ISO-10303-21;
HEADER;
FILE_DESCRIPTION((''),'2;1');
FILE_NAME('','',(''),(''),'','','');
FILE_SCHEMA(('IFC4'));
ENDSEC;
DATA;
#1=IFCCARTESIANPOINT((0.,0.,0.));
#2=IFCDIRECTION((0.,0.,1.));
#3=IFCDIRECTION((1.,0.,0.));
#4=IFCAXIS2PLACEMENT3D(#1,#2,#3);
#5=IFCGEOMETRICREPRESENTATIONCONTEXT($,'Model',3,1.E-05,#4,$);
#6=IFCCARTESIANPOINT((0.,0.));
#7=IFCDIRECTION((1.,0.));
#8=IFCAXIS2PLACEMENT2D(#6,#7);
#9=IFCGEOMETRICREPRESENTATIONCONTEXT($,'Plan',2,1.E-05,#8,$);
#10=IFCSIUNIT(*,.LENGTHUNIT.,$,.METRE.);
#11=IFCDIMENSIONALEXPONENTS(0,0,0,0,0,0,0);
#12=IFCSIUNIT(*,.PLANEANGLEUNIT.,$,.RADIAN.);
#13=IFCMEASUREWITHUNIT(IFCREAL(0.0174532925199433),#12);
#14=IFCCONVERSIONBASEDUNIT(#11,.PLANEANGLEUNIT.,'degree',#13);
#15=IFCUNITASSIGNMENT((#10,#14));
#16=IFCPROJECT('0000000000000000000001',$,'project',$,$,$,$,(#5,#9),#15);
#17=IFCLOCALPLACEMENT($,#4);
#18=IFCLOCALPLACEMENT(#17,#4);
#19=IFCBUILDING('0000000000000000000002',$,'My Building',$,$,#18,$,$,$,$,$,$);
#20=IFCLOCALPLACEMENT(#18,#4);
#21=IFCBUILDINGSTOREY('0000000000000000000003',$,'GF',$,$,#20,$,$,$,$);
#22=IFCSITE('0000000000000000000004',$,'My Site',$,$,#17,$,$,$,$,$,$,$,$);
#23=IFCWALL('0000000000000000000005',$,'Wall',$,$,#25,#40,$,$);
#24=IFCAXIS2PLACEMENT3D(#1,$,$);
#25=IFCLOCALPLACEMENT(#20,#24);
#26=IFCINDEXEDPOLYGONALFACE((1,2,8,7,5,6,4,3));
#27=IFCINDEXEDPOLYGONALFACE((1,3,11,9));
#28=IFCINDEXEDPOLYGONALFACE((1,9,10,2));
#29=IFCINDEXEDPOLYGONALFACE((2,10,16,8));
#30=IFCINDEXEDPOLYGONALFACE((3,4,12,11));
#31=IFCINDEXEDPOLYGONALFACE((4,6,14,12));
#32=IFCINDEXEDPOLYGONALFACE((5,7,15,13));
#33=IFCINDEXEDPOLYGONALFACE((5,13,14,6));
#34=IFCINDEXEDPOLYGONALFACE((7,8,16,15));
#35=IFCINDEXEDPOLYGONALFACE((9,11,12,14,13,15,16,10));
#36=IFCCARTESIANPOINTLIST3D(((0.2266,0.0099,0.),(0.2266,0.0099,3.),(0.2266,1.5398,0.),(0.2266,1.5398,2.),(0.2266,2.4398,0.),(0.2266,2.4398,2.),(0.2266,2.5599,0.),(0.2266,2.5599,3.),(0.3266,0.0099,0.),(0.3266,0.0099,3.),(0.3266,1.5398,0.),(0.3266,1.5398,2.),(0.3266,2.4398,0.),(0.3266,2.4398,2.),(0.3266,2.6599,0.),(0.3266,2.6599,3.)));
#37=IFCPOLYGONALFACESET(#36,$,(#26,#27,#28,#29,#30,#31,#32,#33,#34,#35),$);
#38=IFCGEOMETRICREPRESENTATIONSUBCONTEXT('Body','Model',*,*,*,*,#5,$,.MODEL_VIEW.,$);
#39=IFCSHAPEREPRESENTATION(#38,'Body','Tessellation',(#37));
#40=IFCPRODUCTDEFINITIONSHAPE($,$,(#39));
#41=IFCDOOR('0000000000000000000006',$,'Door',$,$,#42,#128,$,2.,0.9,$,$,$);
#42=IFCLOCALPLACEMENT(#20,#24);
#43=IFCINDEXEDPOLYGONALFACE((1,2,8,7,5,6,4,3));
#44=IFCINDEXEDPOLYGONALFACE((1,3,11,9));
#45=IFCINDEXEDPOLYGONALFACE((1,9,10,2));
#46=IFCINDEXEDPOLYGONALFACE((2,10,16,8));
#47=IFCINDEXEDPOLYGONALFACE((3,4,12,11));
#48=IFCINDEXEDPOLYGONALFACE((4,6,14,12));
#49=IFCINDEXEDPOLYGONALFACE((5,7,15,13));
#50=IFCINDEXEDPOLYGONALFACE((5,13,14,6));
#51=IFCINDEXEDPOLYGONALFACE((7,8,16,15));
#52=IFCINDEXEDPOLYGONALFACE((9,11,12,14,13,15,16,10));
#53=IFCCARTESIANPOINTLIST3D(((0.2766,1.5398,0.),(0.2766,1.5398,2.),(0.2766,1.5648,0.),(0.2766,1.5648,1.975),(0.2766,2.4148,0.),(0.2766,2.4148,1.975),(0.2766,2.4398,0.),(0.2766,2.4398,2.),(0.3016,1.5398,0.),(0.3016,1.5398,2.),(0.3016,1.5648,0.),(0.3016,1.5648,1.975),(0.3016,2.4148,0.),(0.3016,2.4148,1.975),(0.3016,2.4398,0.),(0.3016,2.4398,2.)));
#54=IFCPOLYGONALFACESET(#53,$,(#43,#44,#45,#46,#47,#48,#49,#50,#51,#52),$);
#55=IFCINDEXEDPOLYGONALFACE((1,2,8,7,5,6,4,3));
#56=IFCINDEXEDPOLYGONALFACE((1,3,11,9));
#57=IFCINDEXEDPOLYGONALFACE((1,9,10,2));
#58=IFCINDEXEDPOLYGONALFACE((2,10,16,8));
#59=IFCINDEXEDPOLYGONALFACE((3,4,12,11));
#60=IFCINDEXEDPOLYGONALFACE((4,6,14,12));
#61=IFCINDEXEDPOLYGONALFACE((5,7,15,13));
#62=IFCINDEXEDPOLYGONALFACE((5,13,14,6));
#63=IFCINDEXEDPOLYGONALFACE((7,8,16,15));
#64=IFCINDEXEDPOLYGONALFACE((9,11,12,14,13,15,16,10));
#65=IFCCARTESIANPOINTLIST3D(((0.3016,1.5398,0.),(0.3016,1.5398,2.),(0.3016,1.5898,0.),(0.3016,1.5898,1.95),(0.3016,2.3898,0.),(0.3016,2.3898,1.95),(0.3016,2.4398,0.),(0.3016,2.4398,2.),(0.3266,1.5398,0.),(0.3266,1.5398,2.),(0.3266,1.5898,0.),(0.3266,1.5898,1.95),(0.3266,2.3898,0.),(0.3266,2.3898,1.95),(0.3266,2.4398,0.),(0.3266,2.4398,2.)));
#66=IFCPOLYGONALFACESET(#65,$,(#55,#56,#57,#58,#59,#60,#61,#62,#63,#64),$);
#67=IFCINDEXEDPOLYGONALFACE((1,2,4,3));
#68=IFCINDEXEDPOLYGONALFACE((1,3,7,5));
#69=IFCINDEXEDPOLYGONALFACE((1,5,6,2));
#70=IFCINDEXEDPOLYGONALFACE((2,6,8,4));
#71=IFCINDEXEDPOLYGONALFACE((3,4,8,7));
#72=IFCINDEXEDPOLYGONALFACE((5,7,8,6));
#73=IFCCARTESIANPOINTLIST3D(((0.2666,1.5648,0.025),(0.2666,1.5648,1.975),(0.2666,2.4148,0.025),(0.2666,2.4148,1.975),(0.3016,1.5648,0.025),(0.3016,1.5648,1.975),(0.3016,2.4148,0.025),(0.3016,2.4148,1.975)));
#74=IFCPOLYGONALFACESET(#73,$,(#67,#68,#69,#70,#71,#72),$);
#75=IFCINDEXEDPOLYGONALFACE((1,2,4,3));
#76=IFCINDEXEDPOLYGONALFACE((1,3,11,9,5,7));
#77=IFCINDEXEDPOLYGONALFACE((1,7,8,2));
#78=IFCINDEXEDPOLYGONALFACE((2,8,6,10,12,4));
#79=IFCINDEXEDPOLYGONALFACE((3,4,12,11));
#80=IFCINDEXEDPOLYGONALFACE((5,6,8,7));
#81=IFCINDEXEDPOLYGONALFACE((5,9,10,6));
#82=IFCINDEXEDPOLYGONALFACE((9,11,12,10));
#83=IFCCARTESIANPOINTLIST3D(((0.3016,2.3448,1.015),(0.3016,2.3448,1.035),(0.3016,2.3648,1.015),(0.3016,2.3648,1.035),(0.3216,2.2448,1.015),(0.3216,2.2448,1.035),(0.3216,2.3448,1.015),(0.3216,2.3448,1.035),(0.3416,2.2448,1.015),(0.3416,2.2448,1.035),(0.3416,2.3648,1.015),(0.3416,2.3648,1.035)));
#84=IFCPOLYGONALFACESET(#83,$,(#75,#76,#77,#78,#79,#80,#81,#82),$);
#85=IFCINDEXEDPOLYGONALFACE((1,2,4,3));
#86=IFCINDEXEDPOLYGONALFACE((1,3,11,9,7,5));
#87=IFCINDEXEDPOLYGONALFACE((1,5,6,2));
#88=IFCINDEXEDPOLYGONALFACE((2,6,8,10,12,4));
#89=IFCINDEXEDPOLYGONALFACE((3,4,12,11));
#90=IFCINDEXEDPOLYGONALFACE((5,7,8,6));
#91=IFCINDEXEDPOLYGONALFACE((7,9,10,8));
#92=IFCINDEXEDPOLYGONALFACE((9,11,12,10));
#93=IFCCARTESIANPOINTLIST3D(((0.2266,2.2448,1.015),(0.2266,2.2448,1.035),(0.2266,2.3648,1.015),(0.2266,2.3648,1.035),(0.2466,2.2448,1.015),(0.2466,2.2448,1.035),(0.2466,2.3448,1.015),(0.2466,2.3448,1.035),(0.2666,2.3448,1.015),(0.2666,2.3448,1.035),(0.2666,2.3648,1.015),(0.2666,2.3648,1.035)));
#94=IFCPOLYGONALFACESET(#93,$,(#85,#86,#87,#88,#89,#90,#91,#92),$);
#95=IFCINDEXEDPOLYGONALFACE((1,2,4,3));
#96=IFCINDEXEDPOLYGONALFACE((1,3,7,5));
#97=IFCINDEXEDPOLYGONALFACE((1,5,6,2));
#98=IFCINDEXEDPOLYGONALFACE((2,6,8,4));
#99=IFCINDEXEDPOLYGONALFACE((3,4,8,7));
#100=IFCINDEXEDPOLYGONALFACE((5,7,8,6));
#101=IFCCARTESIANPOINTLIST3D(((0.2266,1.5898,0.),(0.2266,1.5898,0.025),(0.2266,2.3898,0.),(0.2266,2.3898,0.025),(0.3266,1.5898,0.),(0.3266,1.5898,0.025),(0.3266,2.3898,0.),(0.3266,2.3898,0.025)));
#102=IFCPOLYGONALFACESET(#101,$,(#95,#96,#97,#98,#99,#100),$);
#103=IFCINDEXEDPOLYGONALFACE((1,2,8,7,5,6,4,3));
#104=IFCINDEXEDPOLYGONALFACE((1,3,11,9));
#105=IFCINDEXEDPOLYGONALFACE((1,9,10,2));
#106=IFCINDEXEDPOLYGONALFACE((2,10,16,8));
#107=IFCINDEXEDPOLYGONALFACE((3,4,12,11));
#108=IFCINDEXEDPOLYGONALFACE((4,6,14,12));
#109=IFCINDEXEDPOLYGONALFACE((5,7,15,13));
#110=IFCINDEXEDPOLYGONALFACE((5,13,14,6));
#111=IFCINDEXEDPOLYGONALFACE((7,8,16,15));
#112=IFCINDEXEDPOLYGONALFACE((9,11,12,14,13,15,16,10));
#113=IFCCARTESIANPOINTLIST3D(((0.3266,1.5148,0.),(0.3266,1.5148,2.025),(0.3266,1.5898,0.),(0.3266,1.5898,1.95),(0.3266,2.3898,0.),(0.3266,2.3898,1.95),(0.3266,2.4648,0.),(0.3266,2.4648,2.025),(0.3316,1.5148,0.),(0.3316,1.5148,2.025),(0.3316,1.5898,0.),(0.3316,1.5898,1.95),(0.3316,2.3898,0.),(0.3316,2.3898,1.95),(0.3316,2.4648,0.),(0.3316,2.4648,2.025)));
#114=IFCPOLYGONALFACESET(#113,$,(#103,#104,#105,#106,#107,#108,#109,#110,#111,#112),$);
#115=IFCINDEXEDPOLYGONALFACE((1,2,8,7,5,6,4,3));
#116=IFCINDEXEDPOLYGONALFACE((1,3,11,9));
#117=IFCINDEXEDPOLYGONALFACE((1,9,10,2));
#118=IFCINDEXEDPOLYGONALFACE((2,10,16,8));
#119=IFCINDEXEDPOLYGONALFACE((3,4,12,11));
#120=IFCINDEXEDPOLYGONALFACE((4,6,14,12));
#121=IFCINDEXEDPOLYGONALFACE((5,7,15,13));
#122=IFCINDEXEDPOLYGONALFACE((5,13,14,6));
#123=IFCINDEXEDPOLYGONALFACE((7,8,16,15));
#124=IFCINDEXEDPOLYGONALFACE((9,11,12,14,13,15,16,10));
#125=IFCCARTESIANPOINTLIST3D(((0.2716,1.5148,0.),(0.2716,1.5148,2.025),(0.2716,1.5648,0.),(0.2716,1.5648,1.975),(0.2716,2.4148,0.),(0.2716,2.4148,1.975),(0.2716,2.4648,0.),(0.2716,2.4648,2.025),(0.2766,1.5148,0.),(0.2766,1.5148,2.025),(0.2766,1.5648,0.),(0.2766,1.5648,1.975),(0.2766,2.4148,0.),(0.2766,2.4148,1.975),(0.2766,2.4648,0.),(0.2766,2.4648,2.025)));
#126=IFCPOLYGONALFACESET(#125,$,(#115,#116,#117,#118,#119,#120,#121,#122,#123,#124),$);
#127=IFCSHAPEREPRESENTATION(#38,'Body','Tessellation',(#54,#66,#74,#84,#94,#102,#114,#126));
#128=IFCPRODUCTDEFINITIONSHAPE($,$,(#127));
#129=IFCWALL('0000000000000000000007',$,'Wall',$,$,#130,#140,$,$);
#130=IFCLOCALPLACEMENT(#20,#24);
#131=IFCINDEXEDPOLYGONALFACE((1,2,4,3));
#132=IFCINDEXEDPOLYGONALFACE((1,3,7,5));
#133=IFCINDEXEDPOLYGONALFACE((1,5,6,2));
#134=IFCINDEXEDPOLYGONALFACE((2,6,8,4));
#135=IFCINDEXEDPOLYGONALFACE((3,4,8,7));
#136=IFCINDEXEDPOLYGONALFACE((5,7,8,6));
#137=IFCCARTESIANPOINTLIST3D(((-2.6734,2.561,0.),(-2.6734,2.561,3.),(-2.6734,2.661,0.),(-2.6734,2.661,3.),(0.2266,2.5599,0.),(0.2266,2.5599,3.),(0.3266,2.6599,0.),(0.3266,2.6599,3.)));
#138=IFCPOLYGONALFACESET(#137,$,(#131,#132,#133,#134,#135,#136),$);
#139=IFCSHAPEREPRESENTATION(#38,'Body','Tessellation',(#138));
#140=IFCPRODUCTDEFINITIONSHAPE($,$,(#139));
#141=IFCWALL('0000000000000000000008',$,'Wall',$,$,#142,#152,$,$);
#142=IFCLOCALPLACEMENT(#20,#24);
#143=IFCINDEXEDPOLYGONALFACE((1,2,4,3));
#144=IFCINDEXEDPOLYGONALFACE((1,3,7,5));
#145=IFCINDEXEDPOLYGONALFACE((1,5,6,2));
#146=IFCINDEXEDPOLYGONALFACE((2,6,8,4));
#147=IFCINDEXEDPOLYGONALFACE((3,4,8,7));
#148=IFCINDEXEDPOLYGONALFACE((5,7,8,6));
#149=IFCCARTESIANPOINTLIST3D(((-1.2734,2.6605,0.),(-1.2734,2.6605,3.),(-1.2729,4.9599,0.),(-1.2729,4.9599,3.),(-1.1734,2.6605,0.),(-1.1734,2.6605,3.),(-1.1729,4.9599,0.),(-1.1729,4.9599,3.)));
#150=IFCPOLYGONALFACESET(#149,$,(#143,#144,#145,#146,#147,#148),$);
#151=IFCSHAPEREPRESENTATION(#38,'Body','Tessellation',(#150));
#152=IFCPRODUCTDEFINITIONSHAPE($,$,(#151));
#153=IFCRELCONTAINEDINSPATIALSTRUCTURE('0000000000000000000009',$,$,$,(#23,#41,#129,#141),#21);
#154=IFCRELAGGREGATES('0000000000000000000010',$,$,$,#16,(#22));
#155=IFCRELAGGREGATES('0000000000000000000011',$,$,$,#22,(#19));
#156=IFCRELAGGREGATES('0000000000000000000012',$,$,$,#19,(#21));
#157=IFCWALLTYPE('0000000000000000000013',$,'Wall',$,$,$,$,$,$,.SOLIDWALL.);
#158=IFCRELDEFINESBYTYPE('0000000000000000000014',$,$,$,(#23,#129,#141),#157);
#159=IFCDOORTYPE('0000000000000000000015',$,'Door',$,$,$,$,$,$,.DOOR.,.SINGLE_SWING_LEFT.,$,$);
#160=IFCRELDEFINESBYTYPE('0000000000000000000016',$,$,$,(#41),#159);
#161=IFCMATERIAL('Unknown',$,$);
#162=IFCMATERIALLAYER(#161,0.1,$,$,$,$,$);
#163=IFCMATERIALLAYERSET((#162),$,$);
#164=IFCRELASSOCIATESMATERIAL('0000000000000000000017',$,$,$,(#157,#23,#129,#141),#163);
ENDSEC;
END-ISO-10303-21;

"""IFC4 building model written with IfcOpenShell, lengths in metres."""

from ifc_helpers import new_model, entity, si_unit, converted_unit, frame, origin_with_axes, origin_2d_with_axis, place, context, subcontext, project, spatial, line, indexed_curve, outline, extrude, shape, source, transform, mapped, material, layer, layer_set, layer_usage, type_object, type_shapes, element, fill, save


model = new_model("IFC4")

# Units and contexts
model_context = context("Model", 3, precision=1e-05, world=origin_with_axes())
plan_context = context("Plan", 2, precision=1e-05, world=origin_2d_with_axis())
body_context_1 = subcontext(model_context, "Body", "Model", "MODEL_VIEW")
body_context_2 = subcontext(plan_context, "Body", "Plan", "PLAN_VIEW")
ifc_project = project(units=[si_unit("LENGTHUNIT", "METRE"), converted_unit("PLANEANGLEUNIT", "degree", entity("IfcReal", 0.0174532925199433), si_unit("PLANEANGLEUNIT", "RADIAN"), dimensions=[0, 0, 0, 0, 0, 0, 0])], contexts=[model_context, plan_context])

# Site, building, storey
site_placement = place(None, origin_with_axes())
site = spatial("IfcSite", under=ifc_project, at=site_placement, Name="My Site")
building_placement = place(site_placement, origin_with_axes())
building = spatial("IfcBuilding", under=site, at=building_placement, Name="My Building")
storey_placement = place(building_placement, origin_with_axes())
storey = spatial("IfcBuildingStorey", under=building, at=storey_placement, Name="GF")

# Shared definitions
ifc_material = material(Name="Unknown")

# Shared definitions
ifc_layer_1 = layer(ifc_material, 0.1)
ifc_layer_set_1 = layer_set([ifc_layer_1])
wall_type = type_object("IfcWallType", Name="Wall", PredefinedType="SOLIDWALL", material=ifc_layer_set_1)

# Shared definitions
shared_shape_1 = source(origin_with_axes(), body_context_1, "Body", "SweptSolid", [
    extrude(outline(indexed_curve([(0.0, 0.0), (0.9, 0.0), (0.9, 2.0), (0.0, 2.0)], segments=[line(1, 2, 3, 4, 1)])), frame((0.0, -0.6, 0.0), z_axis=(0.0, -1.0, 0.0), x_axis=(1.0, 0.0, 0.0)), (0.0, 0.0, -1.0), 1.2),
])
door_type = type_object("IfcDoorType", Name="Door", OperationType="SINGLE_SWING_LEFT", PredefinedType="DOOR")
shared_shape_2 = source(origin_with_axes(), body_context_1, "Body", "SweptSolid", [
    extrude(outline(indexed_curve([(0.0, 0.0), (0.0, 2.0), (0.9, 2.0), (0.9, 0.0), (0.875, 0.0), (0.875, 1.975), (0.025, 1.975), (0.025, 0.0)], segments=[line(1, 2, 3, 4, 5, 6, 7, 8, 1)])), frame((0.0, 0.025, 0.0), z_axis=(0.0, -1.0, 0.0), x_axis=(1.0, 0.0, 0.0)), (0.0, 0.0, -1.0), 0.025),
    extrude(outline(indexed_curve([(0.0, 0.0), (0.0, 2.0), (0.9, 2.0), (0.9, 0.0), (0.85, 0.0), (0.85, 1.95), (0.05, 1.95), (0.05, 0.0)], segments=[line(1, 2, 3, 4, 5, 6, 7, 8, 1)])), frame((0.0, 0.0, 0.0), z_axis=(0.0, -1.0, 0.0), x_axis=(1.0, 0.0, 0.0)), (0.0, 0.0, -1.0), 0.025),
    extrude(outline(indexed_curve([(0.0, 0.0), (0.85, 0.0), (0.85, 0.035), (0.0, 0.035)], segments=[line(1, 2, 3, 4, 1)])), frame((0.025, 0.025, 0.025), z_axis=(0.0, 0.0, 1.0), x_axis=(1.0, 0.0, 0.0)), (0.0, 0.0, 1.0), 1.95),
    extrude(outline(indexed_curve([(0.0, 0.0), (0.0, -0.04), (-0.12, -0.04), (-0.12, -0.02), (-0.02, -0.02), (-0.02, 0.0)], segments=[line(1, 2, 3, 4, 5, 6, 1)])), frame((0.825, 0.025, 1.015), z_axis=(0.0, 0.0, 1.0), x_axis=(1.0, 0.0, 0.0)), (0.0, 0.0, 1.0), 0.02),
    extrude(outline(indexed_curve([(0.0, 0.0), (0.0, 0.04), (-0.12, 0.04), (-0.12, 0.02), (-0.02, 0.02), (-0.02, 0.0)], segments=[line(1, 2, 3, 4, 5, 6, 1)])), frame((0.825, 0.06, 1.015), z_axis=(0.0, 0.0, 1.0), x_axis=(1.0, 0.0, 0.0)), (0.0, 0.0, 1.0), 0.02),
    extrude(outline(indexed_curve([(0.0, 0.0), (0.8, 0.0), (0.8, 0.1), (0.0, 0.1)], segments=[line(1, 2, 3, 4, 1)])), frame((0.05, 0.0, 0.0), z_axis=(0.0, 0.0, 1.0), x_axis=(1.0, 0.0, 0.0)), (0.0, 0.0, 1.0), 0.025),
    extrude(outline(indexed_curve([(0.0, 0.0), (0.0, 2.025), (0.95, 2.025), (0.95, 0.0), (0.875, 0.0), (0.875, 1.95), (0.075, 1.95), (0.075, 0.0)], segments=[line(1, 2, 3, 4, 5, 6, 7, 8, 1)])), frame((-0.025, -0.005, 0.0), z_axis=(0.0, -1.0, 0.0), x_axis=(1.0, 0.0, 0.0)), (0.0, 0.0, -1.0), 0.005),
    extrude(outline(indexed_curve([(0.0, 0.0), (0.0, 2.025), (0.95, 2.025), (0.95, 0.0), (0.9, 0.0), (0.9, 1.975), (0.05, 1.975), (0.05, 0.0)], segments=[line(1, 2, 3, 4, 5, 6, 7, 8, 1)])), frame((-0.025, 0.05, 0.0), z_axis=(0.0, -1.0, 0.0), x_axis=(1.0, 0.0, 0.0)), (0.0, 0.0, -1.0), 0.005),
])
shared_shape_3 = source(origin_with_axes(), body_context_2, "Body", "Curve2D", [
    entity("IfcIndexedPolyCurve", entity("IfcCartesianPointList2D", [[0.0, 0.0], [0.0, 0.05], [0.025, 0.05], [0.025, 0.025], [0.05, 0.025], [0.05, 0.0]]), [entity("IfcLineIndex", [1, 2, 3, 4, 5, 6, 1])]),
    entity("IfcIndexedPolyCurve", entity("IfcCartesianPointList2D", [[0.9, 0.0], [0.9, 0.05], [0.875, 0.05], [0.875, 0.025], [0.85, 0.025], [0.85, 0.0]]), [entity("IfcLineIndex", [1, 2, 3, 4, 5, 6, 1])]),
    entity("IfcTrimmedCurve", entity("IfcEllipse", entity("IfcAxis2Placement2D", entity("IfcCartesianPoint", [0.06, 0.05]), entity("IfcDirection", [1.0, 0.0])), 0.815, 0.85), [entity("IfcCartesianPoint", [0.875, 0.05])], [entity("IfcCartesianPoint", [0.06, 0.9])], True, "CARTESIAN"),
    entity("IfcIndexedPolyCurve", entity("IfcCartesianPointList2D", [[0.025, 0.05], [0.06, 0.05], [0.06, 0.9], [0.025, 0.9]]), [entity("IfcLineIndex", [1, 2, 3, 4, 1])]),
])
type_shapes(door_type, [shared_shape_2, shared_shape_3])

# Wall, opening, door
ifc_layer_usage_1 = layer_usage(ifc_layer_set_1, "AXIS2", "POSITIVE", 0.0)
wall_1_placement = place(storey_placement, frame((0.3266, 0.0099, 0.0), z_axis=(0.0, 0.0, 1.0), x_axis=(0.0, 1.0, 0.0)))
wall_1 = element("IfcWall", 1, at=wall_1_placement, inside=storey, type_object=wall_type, material=ifc_layer_usage_1, Name="Wall", context=body_context_1, shape_type="SweptSolid", body=[
    extrude(outline(indexed_curve([(0.0, 0.0), (0.0, 0.1), (2.55, 0.1), (2.65, 0.0)], segments=[line(1, 2, 3, 4, 1)])), origin_with_axes(), (0.0, 0.0, 1.0), 3.0),
])
opening_1_placement = place(wall_1_placement, frame((1.5299, 0.0, 0.0), z_axis=(0.0, 0.0, 1.0), x_axis=(1.0, 0.0, 0.0)))
opening_1 = element("IfcOpeningElement", 2, at=opening_1_placement, cuts=wall_1, PredefinedType="OPENING", context=body_context_1, shape_type="MappedRepresentation", body=[
    mapped(shared_shape_1, transform((0.0, 0.0, 0.0), x_axis=(1.0, 0.0, 0.0), y_axis=(0.0, 1.0, 0.0), z_axis=(0.0, 0.0, 1.0), scale=1.0)),
])
door_1_placement = place(opening_1_placement, frame((0.0, 0.0, 0.0), z_axis=(0.0, 0.0, 1.0), x_axis=(1.0, 0.0, 0.0)))
door_1 = element("IfcDoor", 3, at=door_1_placement, inside=storey, type_object=door_type, Name="Door", OverallHeight=2.0, OverallWidth=0.9, shapes=[
    shape(body_context_1, "Body", "MappedRepresentation", [mapped(shared_shape_2, transform((0.0, 0.0, 0.0), x_axis=(1.0, 0.0, 0.0), y_axis=(0.0, 1.0, 0.0), z_axis=(0.0, 0.0, 1.0), scale=1.0))]),
    shape(body_context_2, "Body", "MappedRepresentation", [mapped(shared_shape_3, transform((0.0, 0.0, 0.0), x_axis=(1.0, 0.0, 0.0), y_axis=(0.0, 1.0, 0.0), z_axis=(0.0, 0.0, 1.0), scale=1.0))]),
])
fill(opening_1, door_1)

# Walls
ifc_layer_usage_2 = layer_usage(ifc_layer_set_1, "AXIS2", "POSITIVE", 0.0)
wall_2_placement = place(storey_placement, frame((0.3266, 2.6599, 0.0), z_axis=(0.0, 0.0, 1.0), x_axis=(-1.0, 0.000381, 0.0)))
element("IfcWall", 4, at=wall_2_placement, inside=storey, type_object=wall_type, material=ifc_layer_usage_2, Name="Wall", context=body_context_1, shape_type="SweptSolid", body=[
    extrude(outline(indexed_curve([(0.0, 0.0), (0.1, 0.1), (3.0, 0.1), (3.0, 0.0)], segments=[line(1, 2, 3, 4, 1)])), origin_with_axes(), (0.0, 0.0, 1.0), 3.0),
])
ifc_layer_usage_3 = layer_usage(ifc_layer_set_1, "AXIS2", "POSITIVE", 0.0)
wall_3_placement = place(storey_placement, frame((-1.1734, 2.6605, 0.0), z_axis=(0.0, 0.0, 1.0), x_axis=(0.000197, 1.0, 0.0)))
element("IfcWall", 5, at=wall_3_placement, inside=storey, type_object=wall_type, material=ifc_layer_usage_3, Name="Wall", context=body_context_1, shape_type="SweptSolid", body=[
    extrude(outline(indexed_curve([(0.0, 0.0), (0.0, 0.1), (2.2994, 0.1), (2.2994, 0.0)], segments=[line(1, 2, 3, 4, 1)])), origin_with_axes(), (0.0, 0.0, 1.0), 3.0),
])

save(model, "model.ifc")
